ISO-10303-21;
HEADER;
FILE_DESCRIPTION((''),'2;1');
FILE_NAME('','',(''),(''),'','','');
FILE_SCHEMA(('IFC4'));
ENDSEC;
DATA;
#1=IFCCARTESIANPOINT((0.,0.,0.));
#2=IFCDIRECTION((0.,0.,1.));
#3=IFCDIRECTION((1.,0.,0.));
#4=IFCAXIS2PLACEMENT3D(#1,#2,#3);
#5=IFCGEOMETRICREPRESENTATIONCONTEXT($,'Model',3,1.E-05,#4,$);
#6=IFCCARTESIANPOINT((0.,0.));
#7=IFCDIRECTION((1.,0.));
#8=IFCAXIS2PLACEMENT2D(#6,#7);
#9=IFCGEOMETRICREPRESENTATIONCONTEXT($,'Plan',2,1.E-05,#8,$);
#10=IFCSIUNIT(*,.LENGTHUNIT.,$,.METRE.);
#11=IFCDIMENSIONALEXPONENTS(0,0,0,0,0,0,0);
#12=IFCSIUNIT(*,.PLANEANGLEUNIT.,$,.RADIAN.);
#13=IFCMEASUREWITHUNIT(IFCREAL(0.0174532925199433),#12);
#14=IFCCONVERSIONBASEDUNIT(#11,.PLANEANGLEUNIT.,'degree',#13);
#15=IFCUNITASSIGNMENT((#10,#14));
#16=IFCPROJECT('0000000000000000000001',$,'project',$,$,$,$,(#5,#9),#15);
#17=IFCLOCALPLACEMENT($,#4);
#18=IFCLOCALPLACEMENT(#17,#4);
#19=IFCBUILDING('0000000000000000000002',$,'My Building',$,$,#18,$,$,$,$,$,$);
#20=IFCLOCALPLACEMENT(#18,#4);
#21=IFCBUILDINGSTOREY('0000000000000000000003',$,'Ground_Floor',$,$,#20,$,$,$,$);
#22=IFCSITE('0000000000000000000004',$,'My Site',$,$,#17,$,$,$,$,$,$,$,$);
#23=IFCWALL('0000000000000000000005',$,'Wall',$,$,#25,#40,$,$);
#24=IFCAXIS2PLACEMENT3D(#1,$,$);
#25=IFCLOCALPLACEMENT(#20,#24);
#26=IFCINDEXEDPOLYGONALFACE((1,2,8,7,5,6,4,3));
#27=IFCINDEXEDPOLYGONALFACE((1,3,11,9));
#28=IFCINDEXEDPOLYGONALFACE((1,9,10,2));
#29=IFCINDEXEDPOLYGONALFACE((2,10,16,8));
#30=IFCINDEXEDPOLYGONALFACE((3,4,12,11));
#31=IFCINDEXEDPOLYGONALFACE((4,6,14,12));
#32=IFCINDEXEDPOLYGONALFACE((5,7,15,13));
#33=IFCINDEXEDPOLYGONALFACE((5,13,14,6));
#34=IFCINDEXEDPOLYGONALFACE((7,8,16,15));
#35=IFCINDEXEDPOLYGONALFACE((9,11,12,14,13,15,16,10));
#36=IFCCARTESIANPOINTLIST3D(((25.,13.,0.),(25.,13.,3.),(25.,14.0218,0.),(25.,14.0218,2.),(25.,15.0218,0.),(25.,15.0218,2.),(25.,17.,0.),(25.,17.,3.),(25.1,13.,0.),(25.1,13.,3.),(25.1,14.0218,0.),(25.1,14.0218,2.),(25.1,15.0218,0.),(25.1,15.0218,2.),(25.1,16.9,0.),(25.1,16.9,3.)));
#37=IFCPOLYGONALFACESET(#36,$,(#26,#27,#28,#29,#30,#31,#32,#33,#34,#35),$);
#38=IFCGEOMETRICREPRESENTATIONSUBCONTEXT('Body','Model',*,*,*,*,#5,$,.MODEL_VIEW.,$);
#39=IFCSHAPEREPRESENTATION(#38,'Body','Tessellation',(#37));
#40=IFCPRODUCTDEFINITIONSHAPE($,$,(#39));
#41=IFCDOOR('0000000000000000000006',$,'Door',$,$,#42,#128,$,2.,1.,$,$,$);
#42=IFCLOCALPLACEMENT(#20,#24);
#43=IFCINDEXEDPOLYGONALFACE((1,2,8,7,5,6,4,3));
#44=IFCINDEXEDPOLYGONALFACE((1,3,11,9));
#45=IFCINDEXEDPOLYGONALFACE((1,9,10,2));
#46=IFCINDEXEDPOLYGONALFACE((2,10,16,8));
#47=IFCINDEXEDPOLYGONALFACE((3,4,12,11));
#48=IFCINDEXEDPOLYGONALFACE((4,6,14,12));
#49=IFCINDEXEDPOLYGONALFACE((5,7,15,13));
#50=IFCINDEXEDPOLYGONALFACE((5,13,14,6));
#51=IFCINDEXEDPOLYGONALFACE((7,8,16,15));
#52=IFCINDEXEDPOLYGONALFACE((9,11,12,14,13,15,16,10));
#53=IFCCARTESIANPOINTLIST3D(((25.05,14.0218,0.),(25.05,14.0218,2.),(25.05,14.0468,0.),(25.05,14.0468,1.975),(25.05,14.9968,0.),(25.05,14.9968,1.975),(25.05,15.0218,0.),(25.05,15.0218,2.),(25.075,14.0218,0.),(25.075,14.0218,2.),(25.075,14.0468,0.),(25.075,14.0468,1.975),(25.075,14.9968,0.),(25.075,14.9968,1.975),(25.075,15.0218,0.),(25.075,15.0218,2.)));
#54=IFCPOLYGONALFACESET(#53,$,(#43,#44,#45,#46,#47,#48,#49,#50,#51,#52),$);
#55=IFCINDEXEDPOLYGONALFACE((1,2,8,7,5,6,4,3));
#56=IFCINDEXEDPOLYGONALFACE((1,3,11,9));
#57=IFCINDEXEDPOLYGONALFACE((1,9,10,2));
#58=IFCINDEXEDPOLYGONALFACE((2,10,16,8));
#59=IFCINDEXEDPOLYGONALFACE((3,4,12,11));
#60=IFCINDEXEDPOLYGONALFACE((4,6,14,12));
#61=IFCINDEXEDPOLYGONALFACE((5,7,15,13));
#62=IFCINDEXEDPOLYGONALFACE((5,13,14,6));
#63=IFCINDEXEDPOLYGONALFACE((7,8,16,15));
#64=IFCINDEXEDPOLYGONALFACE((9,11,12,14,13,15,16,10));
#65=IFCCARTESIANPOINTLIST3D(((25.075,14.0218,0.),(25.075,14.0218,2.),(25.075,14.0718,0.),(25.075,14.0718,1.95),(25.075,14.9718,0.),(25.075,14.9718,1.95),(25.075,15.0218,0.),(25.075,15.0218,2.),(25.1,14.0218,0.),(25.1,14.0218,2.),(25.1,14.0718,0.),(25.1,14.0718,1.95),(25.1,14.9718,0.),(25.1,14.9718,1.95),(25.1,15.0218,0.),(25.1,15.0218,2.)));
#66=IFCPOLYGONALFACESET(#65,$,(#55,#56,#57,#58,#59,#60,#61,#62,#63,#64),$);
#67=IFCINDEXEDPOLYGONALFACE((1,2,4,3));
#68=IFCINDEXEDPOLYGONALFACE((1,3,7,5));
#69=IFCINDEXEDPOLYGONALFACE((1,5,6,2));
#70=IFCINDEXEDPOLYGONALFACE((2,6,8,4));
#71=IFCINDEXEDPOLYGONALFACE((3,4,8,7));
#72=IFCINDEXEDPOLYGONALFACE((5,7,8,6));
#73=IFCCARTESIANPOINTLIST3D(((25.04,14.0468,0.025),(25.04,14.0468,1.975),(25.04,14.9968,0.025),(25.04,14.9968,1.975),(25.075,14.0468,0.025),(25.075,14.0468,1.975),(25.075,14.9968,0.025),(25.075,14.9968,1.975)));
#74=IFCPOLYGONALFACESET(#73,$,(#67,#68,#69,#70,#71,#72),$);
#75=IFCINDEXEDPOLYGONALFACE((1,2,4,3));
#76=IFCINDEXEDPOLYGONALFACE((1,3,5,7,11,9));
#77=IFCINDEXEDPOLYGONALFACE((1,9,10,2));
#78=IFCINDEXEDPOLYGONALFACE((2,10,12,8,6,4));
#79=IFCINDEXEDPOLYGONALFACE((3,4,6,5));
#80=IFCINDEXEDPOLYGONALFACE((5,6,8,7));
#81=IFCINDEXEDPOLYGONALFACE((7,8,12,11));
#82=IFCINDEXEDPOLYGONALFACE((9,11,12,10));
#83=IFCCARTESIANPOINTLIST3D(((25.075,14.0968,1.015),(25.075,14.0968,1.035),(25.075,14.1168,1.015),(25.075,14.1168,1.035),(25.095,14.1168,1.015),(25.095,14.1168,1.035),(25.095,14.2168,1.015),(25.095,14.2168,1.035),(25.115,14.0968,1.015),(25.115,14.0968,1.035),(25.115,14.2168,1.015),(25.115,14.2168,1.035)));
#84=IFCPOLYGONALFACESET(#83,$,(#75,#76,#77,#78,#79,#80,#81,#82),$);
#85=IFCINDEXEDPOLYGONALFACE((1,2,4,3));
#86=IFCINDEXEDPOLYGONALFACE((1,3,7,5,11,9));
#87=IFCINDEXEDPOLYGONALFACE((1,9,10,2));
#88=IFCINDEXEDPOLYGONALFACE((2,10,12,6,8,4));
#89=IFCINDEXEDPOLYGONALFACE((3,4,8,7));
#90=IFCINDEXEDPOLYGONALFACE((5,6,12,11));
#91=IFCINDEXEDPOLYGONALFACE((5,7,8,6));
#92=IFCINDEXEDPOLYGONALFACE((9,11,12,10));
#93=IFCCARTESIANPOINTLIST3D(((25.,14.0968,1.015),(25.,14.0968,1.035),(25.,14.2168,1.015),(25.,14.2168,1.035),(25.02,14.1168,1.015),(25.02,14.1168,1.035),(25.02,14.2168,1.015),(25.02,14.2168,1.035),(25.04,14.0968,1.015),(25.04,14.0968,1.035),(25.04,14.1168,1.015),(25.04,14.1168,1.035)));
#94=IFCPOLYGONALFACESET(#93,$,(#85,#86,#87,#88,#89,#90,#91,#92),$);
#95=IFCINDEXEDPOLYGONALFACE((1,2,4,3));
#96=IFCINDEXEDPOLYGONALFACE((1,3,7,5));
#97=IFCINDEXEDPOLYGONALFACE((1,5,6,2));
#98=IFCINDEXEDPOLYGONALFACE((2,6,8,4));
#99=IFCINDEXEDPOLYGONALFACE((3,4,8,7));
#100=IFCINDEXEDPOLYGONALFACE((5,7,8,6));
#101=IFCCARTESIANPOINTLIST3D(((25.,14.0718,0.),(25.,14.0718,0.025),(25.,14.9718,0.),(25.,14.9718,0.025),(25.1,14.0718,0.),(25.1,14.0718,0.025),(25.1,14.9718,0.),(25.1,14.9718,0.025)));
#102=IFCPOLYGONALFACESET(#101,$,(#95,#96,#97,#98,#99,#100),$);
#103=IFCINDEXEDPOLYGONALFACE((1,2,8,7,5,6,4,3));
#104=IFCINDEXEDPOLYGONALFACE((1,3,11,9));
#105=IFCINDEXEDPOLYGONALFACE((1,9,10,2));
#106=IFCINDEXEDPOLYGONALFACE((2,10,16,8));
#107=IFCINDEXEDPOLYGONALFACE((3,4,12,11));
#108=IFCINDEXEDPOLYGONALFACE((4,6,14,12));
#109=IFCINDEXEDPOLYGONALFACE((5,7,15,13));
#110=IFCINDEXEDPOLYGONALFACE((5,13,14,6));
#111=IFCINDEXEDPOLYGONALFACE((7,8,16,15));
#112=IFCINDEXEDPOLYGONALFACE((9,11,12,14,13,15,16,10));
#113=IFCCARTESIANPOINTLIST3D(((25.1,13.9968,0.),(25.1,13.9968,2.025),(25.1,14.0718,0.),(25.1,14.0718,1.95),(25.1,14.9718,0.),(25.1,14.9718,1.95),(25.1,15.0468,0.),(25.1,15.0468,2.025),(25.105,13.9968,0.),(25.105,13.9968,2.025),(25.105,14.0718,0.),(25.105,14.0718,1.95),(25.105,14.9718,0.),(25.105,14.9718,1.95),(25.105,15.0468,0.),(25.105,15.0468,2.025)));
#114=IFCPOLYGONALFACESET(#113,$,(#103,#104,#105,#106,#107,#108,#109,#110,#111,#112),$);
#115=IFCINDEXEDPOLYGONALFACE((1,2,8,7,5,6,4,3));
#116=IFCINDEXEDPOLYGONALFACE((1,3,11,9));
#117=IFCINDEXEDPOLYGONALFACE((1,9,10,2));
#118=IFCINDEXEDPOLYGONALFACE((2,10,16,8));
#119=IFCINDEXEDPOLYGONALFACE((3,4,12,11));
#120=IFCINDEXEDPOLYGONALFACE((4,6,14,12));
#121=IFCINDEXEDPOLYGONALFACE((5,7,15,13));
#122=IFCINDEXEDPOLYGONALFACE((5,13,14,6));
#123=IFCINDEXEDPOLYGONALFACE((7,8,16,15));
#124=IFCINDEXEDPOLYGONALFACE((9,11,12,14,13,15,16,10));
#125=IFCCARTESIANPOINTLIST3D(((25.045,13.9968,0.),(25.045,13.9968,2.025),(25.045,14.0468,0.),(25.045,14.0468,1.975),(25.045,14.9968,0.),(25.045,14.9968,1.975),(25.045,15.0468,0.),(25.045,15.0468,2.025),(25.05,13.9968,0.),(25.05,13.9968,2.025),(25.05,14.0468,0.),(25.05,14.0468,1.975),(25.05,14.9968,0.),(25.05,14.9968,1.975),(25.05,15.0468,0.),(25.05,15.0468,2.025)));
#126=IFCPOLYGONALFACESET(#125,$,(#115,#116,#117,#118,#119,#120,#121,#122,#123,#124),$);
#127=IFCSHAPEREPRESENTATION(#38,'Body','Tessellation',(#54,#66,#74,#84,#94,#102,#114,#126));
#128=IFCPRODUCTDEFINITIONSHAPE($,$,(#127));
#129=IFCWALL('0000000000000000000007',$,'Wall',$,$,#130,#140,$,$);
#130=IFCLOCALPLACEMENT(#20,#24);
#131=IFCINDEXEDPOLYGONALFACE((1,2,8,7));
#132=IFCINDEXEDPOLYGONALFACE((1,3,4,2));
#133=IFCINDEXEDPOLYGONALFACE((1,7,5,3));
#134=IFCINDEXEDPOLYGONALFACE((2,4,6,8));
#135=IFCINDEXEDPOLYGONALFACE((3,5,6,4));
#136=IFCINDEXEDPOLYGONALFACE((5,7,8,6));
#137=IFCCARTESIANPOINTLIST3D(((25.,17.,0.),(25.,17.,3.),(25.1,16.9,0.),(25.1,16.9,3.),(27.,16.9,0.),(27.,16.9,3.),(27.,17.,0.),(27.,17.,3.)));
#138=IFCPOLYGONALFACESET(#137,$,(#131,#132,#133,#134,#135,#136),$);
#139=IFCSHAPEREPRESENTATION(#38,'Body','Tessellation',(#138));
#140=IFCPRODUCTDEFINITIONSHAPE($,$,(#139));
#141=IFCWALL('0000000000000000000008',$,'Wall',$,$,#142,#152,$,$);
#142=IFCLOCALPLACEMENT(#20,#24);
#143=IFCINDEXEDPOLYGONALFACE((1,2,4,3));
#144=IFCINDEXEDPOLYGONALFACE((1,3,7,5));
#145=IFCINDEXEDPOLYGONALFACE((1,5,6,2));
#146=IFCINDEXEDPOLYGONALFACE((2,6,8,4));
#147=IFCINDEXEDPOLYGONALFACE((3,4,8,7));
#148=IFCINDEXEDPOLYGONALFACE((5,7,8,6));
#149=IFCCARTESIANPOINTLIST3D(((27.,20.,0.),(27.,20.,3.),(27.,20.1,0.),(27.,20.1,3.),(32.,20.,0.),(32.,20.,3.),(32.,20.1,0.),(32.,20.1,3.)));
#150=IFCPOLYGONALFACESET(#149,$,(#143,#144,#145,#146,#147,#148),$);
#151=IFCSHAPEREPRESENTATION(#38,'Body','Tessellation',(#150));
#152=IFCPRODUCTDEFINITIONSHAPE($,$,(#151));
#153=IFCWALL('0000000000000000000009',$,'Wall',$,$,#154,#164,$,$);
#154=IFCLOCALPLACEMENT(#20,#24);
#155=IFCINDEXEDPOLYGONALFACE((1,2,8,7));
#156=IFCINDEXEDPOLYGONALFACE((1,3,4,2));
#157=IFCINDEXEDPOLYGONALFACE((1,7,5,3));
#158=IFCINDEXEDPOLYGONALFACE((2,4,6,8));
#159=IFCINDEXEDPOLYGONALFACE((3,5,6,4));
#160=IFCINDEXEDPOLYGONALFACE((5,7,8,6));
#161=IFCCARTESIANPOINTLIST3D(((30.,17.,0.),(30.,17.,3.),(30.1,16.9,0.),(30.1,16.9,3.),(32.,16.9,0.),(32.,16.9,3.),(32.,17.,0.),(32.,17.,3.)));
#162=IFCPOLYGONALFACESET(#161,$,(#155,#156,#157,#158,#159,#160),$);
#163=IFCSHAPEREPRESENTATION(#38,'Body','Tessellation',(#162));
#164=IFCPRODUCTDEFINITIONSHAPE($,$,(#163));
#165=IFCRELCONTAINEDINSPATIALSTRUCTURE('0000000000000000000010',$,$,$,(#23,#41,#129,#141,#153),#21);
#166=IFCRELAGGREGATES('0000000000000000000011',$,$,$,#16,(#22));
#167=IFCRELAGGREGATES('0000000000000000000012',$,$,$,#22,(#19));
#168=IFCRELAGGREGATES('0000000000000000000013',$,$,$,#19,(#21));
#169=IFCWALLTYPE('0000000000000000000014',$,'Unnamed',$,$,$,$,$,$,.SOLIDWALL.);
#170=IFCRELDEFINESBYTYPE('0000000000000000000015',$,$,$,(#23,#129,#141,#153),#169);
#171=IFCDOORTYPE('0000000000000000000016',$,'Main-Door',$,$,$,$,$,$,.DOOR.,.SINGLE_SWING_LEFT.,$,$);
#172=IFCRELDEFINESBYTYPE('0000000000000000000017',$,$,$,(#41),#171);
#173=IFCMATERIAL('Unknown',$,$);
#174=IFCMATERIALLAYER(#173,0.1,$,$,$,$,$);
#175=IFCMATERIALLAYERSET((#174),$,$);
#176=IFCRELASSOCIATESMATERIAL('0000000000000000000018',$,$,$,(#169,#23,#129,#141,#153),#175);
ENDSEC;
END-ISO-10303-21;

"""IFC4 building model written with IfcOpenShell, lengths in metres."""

from ifc_helpers import new_model, entity, si_unit, converted_unit, frame, origin_with_axes, origin_2d_with_axis, place, context, subcontext, project, spatial, line, indexed_curve, outline, extrude, shape, source, transform, mapped, material, layer, layer_set, layer_usage, type_object, type_shapes, element, fill, save


model = new_model("IFC4")

# Units and contexts
model_context = context("Model", 3, precision=1e-05, world=origin_with_axes())
plan_context = context("Plan", 2, precision=1e-05, world=origin_2d_with_axis())
body_context_1 = subcontext(model_context, "Body", "Model", "MODEL_VIEW")
body_context_2 = subcontext(plan_context, "Body", "Plan", "PLAN_VIEW")
ifc_project = project(units=[si_unit("LENGTHUNIT", "METRE"), converted_unit("PLANEANGLEUNIT", "degree", entity("IfcReal", 0.0174532925199433), si_unit("PLANEANGLEUNIT", "RADIAN"), dimensions=[0, 0, 0, 0, 0, 0, 0])], contexts=[model_context, plan_context])

# Site, building, storey
site_placement = place(None, origin_with_axes())
site = spatial("IfcSite", under=ifc_project, at=site_placement, Name="My Site")
building_placement = place(site_placement, origin_with_axes())
building = spatial("IfcBuilding", under=site, at=building_placement, Name="My Building")
storey_placement = place(building_placement, origin_with_axes())
storey = spatial("IfcBuildingStorey", under=building, at=storey_placement, Name="Ground_Floor")

# Shared definitions
ifc_material = material(Name="Unknown")
ifc_layer = layer(ifc_material, 0.1)
ifc_layer_set = layer_set([ifc_layer])
wall_type = type_object("IfcWallType", Name="Unnamed", PredefinedType="SOLIDWALL", material=ifc_layer_set)

# Shared definitions
shared_shape_1 = source(origin_with_axes(), body_context_1, "Body", "SweptSolid", [
    extrude(outline(indexed_curve([(0.0, 0.0), (1.0, 0.0), (1.0, 2.0), (0.0, 2.0)], segments=[line(1, 2, 3, 4, 1)])), frame((0.0, -0.6, 0.0), z_axis=(0.0, -1.0, 0.0), x_axis=(1.0, 0.0, 0.0)), (0.0, 0.0, -1.0), 1.2),
])
door_type_1 = type_object("IfcDoorType", Name="Main-Door", OperationType="SINGLE_SWING_LEFT", PredefinedType="DOOR")
shared_shape_2 = source(origin_with_axes(), body_context_1, "Body", "SweptSolid", [
    extrude(outline(indexed_curve([(0.0, 0.0), (0.0, 2.0), (1.0, 2.0), (1.0, 0.0), (0.975, 0.0), (0.975, 1.975), (0.025, 1.975), (0.025, 0.0)], segments=[line(1, 2, 3, 4, 5, 6, 7, 8, 1)])), frame((0.0, 0.025, 0.0), z_axis=(0.0, -1.0, 0.0), x_axis=(1.0, 0.0, 0.0)), (0.0, 0.0, -1.0), 0.025),
    extrude(outline(indexed_curve([(0.0, 0.0), (0.0, 2.0), (1.0, 2.0), (1.0, 0.0), (0.95, 0.0), (0.95, 1.95), (0.05, 1.95), (0.05, 0.0)], segments=[line(1, 2, 3, 4, 5, 6, 7, 8, 1)])), frame((0.0, 0.0, 0.0), z_axis=(0.0, -1.0, 0.0), x_axis=(1.0, 0.0, 0.0)), (0.0, 0.0, -1.0), 0.025),
    extrude(outline(indexed_curve([(0.0, 0.0), (0.95, 0.0), (0.95, 0.035), (0.0, 0.035)], segments=[line(1, 2, 3, 4, 1)])), frame((0.025, 0.025, 0.025), z_axis=(0.0, 0.0, 1.0), x_axis=(1.0, 0.0, 0.0)), (0.0, 0.0, 1.0), 1.95),
    extrude(outline(indexed_curve([(0.0, 0.0), (0.0, -0.04), (0.12, -0.04), (0.12, -0.02), (0.02, -0.02), (0.02, 0.0)], segments=[line(1, 2, 3, 4, 5, 6, 1)])), frame((0.075, 0.025, 1.015), z_axis=(0.0, 0.0, 1.0), x_axis=(1.0, 0.0, 0.0)), (0.0, 0.0, 1.0), 0.02),
    extrude(outline(indexed_curve([(0.0, 0.0), (0.0, 0.04), (0.12, 0.04), (0.12, 0.02), (0.02, 0.02), (0.02, 0.0)], segments=[line(1, 2, 3, 4, 5, 6, 1)])), frame((0.075, 0.06, 1.015), z_axis=(0.0, 0.0, 1.0), x_axis=(1.0, 0.0, 0.0)), (0.0, 0.0, 1.0), 0.02),
    extrude(outline(indexed_curve([(0.0, 0.0), (0.9, 0.0), (0.9, 0.1), (0.0, 0.1)], segments=[line(1, 2, 3, 4, 1)])), frame((0.05, 0.0, 0.0), z_axis=(0.0, 0.0, 1.0), x_axis=(1.0, 0.0, 0.0)), (0.0, 0.0, 1.0), 0.025),
    extrude(outline(indexed_curve([(0.0, 0.0), (0.0, 2.025), (1.05, 2.025), (1.05, 0.0), (0.975, 0.0), (0.975, 1.95), (0.075, 1.95), (0.075, 0.0)], segments=[line(1, 2, 3, 4, 5, 6, 7, 8, 1)])), frame((-0.025, -0.005, 0.0), z_axis=(0.0, -1.0, 0.0), x_axis=(1.0, 0.0, 0.0)), (0.0, 0.0, -1.0), 0.005),
    extrude(outline(indexed_curve([(0.0, 0.0), (0.0, 2.025), (1.05, 2.025), (1.05, 0.0), (1.0, 0.0), (1.0, 1.975), (0.05, 1.975), (0.05, 0.0)], segments=[line(1, 2, 3, 4, 5, 6, 7, 8, 1)])), frame((-0.025, 0.05, 0.0), z_axis=(0.0, -1.0, 0.0), x_axis=(1.0, 0.0, 0.0)), (0.0, 0.0, -1.0), 0.005),
])
shared_shape_3 = source(origin_with_axes(), body_context_2, "Body", "Curve2D", [
    entity("IfcIndexedPolyCurve", entity("IfcCartesianPointList2D", [[0.0, 0.0], [0.0, 0.05], [0.025, 0.05], [0.025, 0.025], [0.05, 0.025], [0.05, 0.0]]), [entity("IfcLineIndex", [1, 2, 3, 4, 5, 6, 1])]),
    entity("IfcIndexedPolyCurve", entity("IfcCartesianPointList2D", [[1.0, 0.0], [1.0, 0.05], [0.975, 0.05], [0.975, 0.025], [0.95, 0.025], [0.95, 0.0]]), [entity("IfcLineIndex", [1, 2, 3, 4, 5, 6, 1])]),
    entity("IfcTrimmedCurve", entity("IfcEllipse", entity("IfcAxis2Placement2D", entity("IfcCartesianPoint", [0.94, 0.05]), entity("IfcDirection", [1.0, 0.0])), 0.915, 0.95), [entity("IfcCartesianPoint", [0.94, 1.0])], [entity("IfcCartesianPoint", [0.025, 0.05])], True, "CARTESIAN"),
    entity("IfcIndexedPolyCurve", entity("IfcCartesianPointList2D", [[0.975, 0.05], [0.94, 0.05], [0.94, 1.0], [0.975, 1.0]]), [entity("IfcLineIndex", [1, 2, 3, 4, 1])]),
])
type_shapes(door_type_1, [shared_shape_2, shared_shape_3])

# Wall, opening, door
ifc_layer_usage_1 = layer_usage(ifc_layer_set, "AXIS2", "POSITIVE", 0.0)
wall_1_placement = place(storey_placement, frame((25.0, 17.0, 0.0), z_axis=(0.0, 0.0, 1.0), x_axis=(0.0, -1.0, 0.0)))
wall_1 = element("IfcWall", 1, at=wall_1_placement, inside=storey, type_object=wall_type, material=ifc_layer_usage_1, Name="Wall", context=body_context_1, shape_type="SweptSolid", body=[
    extrude(outline(indexed_curve([(0.0, 0.0), (0.1, 0.1), (4.0, 0.1), (4.0, 0.0)], segments=[line(1, 2, 3, 4, 1)])), origin_with_axes(), (0.0, 0.0, 1.0), 3.0),
])
opening_1_placement = place(wall_1_placement, frame((2.9782, 0.1, 0.0), z_axis=(0.0, 0.0, 1.0), x_axis=(-1.0, 0.0, 0.0)))
opening_1 = element("IfcOpeningElement", 2, at=opening_1_placement, cuts=wall_1, PredefinedType="OPENING", context=body_context_1, shape_type="MappedRepresentation", body=[
    mapped(shared_shape_1, transform((0.0, 0.0, 0.0), x_axis=(1.0, 0.0, 0.0), y_axis=(0.0, 1.0, 0.0), z_axis=(0.0, 0.0, 1.0), scale=1.0)),
])
door_1_placement = place(opening_1_placement, frame((0.0, 0.0, 0.0), z_axis=(0.0, 0.0, 1.0), x_axis=(1.0, 0.0, 0.0)))
door_1 = element("IfcDoor", 3, at=door_1_placement, inside=storey, type_object=door_type_1, Name="Door", OverallHeight=2.0, OverallWidth=1.0, shapes=[
    shape(body_context_1, "Body", "MappedRepresentation", [mapped(shared_shape_2, transform((0.0, 0.0, 0.0), x_axis=(1.0, 0.0, 0.0), y_axis=(0.0, 1.0, 0.0), z_axis=(0.0, 0.0, 1.0), scale=1.0))]),
    shape(body_context_2, "Body", "MappedRepresentation", [mapped(shared_shape_3, transform((0.0, 0.0, 0.0), x_axis=(1.0, 0.0, 0.0), y_axis=(0.0, 1.0, 0.0), z_axis=(0.0, 0.0, 1.0), scale=1.0))]),
])
fill(opening_1, door_1)

# Walls
ifc_layer_usage_2 = layer_usage(ifc_layer_set, "AXIS2", "POSITIVE", 0.0)
wall_2_placement = place(storey_placement, frame((27.0, 17.0, 0.0), z_axis=(0.0, 0.0, 1.0), x_axis=(-1.0, 0.0, 0.0)))
element("IfcWall", 4, at=wall_2_placement, inside=storey, type_object=wall_type, material=ifc_layer_usage_2, Name="Wall", context=body_context_1, shape_type="SweptSolid", body=[
    extrude(outline(indexed_curve([(0.0, 0.0), (0.0, 0.1), (1.9, 0.1), (2.0, 0.0)], segments=[line(1, 2, 3, 4, 1)])), origin_with_axes(), (0.0, 0.0, 1.0), 3.0),
])
ifc_layer_usage_3 = layer_usage(ifc_layer_set, "AXIS2", "POSITIVE", 0.0)
wall_3_placement = place(storey_placement, frame((27.0, 20.0, 0.0), z_axis=(0.0, 0.0, 1.0), x_axis=(1.0, 0.0, 0.0)))
element("IfcWall", 5, at=wall_3_placement, inside=storey, type_object=wall_type, material=ifc_layer_usage_3, Name="Wall", context=body_context_1, shape_type="SweptSolid", body=[
    extrude(outline(indexed_curve([(0.0, 0.0), (0.0, 0.1), (5.0, 0.1), (5.0, 0.0)], segments=[line(1, 2, 3, 4, 1)])), origin_with_axes(), (0.0, 0.0, 1.0), 3.0),
])
ifc_layer_usage_4 = layer_usage(ifc_layer_set, "AXIS2", "POSITIVE", 0.0)
wall_4_placement = place(storey_placement, frame((32.0, 17.0, 0.0), z_axis=(0.0, 0.0, 1.0), x_axis=(-1.0, 0.0, 0.0)))
element("IfcWall", 6, at=wall_4_placement, inside=storey, type_object=wall_type, material=ifc_layer_usage_4, Name="Wall", context=body_context_1, shape_type="SweptSolid", body=[
    extrude(outline(indexed_curve([(0.0, 0.0), (0.0, 0.1), (1.9, 0.1), (2.0, 0.0)], segments=[line(1, 2, 3, 4, 1)])), origin_with_axes(), (0.0, 0.0, 1.0), 3.0),
])

save(model, "model.ifc")
